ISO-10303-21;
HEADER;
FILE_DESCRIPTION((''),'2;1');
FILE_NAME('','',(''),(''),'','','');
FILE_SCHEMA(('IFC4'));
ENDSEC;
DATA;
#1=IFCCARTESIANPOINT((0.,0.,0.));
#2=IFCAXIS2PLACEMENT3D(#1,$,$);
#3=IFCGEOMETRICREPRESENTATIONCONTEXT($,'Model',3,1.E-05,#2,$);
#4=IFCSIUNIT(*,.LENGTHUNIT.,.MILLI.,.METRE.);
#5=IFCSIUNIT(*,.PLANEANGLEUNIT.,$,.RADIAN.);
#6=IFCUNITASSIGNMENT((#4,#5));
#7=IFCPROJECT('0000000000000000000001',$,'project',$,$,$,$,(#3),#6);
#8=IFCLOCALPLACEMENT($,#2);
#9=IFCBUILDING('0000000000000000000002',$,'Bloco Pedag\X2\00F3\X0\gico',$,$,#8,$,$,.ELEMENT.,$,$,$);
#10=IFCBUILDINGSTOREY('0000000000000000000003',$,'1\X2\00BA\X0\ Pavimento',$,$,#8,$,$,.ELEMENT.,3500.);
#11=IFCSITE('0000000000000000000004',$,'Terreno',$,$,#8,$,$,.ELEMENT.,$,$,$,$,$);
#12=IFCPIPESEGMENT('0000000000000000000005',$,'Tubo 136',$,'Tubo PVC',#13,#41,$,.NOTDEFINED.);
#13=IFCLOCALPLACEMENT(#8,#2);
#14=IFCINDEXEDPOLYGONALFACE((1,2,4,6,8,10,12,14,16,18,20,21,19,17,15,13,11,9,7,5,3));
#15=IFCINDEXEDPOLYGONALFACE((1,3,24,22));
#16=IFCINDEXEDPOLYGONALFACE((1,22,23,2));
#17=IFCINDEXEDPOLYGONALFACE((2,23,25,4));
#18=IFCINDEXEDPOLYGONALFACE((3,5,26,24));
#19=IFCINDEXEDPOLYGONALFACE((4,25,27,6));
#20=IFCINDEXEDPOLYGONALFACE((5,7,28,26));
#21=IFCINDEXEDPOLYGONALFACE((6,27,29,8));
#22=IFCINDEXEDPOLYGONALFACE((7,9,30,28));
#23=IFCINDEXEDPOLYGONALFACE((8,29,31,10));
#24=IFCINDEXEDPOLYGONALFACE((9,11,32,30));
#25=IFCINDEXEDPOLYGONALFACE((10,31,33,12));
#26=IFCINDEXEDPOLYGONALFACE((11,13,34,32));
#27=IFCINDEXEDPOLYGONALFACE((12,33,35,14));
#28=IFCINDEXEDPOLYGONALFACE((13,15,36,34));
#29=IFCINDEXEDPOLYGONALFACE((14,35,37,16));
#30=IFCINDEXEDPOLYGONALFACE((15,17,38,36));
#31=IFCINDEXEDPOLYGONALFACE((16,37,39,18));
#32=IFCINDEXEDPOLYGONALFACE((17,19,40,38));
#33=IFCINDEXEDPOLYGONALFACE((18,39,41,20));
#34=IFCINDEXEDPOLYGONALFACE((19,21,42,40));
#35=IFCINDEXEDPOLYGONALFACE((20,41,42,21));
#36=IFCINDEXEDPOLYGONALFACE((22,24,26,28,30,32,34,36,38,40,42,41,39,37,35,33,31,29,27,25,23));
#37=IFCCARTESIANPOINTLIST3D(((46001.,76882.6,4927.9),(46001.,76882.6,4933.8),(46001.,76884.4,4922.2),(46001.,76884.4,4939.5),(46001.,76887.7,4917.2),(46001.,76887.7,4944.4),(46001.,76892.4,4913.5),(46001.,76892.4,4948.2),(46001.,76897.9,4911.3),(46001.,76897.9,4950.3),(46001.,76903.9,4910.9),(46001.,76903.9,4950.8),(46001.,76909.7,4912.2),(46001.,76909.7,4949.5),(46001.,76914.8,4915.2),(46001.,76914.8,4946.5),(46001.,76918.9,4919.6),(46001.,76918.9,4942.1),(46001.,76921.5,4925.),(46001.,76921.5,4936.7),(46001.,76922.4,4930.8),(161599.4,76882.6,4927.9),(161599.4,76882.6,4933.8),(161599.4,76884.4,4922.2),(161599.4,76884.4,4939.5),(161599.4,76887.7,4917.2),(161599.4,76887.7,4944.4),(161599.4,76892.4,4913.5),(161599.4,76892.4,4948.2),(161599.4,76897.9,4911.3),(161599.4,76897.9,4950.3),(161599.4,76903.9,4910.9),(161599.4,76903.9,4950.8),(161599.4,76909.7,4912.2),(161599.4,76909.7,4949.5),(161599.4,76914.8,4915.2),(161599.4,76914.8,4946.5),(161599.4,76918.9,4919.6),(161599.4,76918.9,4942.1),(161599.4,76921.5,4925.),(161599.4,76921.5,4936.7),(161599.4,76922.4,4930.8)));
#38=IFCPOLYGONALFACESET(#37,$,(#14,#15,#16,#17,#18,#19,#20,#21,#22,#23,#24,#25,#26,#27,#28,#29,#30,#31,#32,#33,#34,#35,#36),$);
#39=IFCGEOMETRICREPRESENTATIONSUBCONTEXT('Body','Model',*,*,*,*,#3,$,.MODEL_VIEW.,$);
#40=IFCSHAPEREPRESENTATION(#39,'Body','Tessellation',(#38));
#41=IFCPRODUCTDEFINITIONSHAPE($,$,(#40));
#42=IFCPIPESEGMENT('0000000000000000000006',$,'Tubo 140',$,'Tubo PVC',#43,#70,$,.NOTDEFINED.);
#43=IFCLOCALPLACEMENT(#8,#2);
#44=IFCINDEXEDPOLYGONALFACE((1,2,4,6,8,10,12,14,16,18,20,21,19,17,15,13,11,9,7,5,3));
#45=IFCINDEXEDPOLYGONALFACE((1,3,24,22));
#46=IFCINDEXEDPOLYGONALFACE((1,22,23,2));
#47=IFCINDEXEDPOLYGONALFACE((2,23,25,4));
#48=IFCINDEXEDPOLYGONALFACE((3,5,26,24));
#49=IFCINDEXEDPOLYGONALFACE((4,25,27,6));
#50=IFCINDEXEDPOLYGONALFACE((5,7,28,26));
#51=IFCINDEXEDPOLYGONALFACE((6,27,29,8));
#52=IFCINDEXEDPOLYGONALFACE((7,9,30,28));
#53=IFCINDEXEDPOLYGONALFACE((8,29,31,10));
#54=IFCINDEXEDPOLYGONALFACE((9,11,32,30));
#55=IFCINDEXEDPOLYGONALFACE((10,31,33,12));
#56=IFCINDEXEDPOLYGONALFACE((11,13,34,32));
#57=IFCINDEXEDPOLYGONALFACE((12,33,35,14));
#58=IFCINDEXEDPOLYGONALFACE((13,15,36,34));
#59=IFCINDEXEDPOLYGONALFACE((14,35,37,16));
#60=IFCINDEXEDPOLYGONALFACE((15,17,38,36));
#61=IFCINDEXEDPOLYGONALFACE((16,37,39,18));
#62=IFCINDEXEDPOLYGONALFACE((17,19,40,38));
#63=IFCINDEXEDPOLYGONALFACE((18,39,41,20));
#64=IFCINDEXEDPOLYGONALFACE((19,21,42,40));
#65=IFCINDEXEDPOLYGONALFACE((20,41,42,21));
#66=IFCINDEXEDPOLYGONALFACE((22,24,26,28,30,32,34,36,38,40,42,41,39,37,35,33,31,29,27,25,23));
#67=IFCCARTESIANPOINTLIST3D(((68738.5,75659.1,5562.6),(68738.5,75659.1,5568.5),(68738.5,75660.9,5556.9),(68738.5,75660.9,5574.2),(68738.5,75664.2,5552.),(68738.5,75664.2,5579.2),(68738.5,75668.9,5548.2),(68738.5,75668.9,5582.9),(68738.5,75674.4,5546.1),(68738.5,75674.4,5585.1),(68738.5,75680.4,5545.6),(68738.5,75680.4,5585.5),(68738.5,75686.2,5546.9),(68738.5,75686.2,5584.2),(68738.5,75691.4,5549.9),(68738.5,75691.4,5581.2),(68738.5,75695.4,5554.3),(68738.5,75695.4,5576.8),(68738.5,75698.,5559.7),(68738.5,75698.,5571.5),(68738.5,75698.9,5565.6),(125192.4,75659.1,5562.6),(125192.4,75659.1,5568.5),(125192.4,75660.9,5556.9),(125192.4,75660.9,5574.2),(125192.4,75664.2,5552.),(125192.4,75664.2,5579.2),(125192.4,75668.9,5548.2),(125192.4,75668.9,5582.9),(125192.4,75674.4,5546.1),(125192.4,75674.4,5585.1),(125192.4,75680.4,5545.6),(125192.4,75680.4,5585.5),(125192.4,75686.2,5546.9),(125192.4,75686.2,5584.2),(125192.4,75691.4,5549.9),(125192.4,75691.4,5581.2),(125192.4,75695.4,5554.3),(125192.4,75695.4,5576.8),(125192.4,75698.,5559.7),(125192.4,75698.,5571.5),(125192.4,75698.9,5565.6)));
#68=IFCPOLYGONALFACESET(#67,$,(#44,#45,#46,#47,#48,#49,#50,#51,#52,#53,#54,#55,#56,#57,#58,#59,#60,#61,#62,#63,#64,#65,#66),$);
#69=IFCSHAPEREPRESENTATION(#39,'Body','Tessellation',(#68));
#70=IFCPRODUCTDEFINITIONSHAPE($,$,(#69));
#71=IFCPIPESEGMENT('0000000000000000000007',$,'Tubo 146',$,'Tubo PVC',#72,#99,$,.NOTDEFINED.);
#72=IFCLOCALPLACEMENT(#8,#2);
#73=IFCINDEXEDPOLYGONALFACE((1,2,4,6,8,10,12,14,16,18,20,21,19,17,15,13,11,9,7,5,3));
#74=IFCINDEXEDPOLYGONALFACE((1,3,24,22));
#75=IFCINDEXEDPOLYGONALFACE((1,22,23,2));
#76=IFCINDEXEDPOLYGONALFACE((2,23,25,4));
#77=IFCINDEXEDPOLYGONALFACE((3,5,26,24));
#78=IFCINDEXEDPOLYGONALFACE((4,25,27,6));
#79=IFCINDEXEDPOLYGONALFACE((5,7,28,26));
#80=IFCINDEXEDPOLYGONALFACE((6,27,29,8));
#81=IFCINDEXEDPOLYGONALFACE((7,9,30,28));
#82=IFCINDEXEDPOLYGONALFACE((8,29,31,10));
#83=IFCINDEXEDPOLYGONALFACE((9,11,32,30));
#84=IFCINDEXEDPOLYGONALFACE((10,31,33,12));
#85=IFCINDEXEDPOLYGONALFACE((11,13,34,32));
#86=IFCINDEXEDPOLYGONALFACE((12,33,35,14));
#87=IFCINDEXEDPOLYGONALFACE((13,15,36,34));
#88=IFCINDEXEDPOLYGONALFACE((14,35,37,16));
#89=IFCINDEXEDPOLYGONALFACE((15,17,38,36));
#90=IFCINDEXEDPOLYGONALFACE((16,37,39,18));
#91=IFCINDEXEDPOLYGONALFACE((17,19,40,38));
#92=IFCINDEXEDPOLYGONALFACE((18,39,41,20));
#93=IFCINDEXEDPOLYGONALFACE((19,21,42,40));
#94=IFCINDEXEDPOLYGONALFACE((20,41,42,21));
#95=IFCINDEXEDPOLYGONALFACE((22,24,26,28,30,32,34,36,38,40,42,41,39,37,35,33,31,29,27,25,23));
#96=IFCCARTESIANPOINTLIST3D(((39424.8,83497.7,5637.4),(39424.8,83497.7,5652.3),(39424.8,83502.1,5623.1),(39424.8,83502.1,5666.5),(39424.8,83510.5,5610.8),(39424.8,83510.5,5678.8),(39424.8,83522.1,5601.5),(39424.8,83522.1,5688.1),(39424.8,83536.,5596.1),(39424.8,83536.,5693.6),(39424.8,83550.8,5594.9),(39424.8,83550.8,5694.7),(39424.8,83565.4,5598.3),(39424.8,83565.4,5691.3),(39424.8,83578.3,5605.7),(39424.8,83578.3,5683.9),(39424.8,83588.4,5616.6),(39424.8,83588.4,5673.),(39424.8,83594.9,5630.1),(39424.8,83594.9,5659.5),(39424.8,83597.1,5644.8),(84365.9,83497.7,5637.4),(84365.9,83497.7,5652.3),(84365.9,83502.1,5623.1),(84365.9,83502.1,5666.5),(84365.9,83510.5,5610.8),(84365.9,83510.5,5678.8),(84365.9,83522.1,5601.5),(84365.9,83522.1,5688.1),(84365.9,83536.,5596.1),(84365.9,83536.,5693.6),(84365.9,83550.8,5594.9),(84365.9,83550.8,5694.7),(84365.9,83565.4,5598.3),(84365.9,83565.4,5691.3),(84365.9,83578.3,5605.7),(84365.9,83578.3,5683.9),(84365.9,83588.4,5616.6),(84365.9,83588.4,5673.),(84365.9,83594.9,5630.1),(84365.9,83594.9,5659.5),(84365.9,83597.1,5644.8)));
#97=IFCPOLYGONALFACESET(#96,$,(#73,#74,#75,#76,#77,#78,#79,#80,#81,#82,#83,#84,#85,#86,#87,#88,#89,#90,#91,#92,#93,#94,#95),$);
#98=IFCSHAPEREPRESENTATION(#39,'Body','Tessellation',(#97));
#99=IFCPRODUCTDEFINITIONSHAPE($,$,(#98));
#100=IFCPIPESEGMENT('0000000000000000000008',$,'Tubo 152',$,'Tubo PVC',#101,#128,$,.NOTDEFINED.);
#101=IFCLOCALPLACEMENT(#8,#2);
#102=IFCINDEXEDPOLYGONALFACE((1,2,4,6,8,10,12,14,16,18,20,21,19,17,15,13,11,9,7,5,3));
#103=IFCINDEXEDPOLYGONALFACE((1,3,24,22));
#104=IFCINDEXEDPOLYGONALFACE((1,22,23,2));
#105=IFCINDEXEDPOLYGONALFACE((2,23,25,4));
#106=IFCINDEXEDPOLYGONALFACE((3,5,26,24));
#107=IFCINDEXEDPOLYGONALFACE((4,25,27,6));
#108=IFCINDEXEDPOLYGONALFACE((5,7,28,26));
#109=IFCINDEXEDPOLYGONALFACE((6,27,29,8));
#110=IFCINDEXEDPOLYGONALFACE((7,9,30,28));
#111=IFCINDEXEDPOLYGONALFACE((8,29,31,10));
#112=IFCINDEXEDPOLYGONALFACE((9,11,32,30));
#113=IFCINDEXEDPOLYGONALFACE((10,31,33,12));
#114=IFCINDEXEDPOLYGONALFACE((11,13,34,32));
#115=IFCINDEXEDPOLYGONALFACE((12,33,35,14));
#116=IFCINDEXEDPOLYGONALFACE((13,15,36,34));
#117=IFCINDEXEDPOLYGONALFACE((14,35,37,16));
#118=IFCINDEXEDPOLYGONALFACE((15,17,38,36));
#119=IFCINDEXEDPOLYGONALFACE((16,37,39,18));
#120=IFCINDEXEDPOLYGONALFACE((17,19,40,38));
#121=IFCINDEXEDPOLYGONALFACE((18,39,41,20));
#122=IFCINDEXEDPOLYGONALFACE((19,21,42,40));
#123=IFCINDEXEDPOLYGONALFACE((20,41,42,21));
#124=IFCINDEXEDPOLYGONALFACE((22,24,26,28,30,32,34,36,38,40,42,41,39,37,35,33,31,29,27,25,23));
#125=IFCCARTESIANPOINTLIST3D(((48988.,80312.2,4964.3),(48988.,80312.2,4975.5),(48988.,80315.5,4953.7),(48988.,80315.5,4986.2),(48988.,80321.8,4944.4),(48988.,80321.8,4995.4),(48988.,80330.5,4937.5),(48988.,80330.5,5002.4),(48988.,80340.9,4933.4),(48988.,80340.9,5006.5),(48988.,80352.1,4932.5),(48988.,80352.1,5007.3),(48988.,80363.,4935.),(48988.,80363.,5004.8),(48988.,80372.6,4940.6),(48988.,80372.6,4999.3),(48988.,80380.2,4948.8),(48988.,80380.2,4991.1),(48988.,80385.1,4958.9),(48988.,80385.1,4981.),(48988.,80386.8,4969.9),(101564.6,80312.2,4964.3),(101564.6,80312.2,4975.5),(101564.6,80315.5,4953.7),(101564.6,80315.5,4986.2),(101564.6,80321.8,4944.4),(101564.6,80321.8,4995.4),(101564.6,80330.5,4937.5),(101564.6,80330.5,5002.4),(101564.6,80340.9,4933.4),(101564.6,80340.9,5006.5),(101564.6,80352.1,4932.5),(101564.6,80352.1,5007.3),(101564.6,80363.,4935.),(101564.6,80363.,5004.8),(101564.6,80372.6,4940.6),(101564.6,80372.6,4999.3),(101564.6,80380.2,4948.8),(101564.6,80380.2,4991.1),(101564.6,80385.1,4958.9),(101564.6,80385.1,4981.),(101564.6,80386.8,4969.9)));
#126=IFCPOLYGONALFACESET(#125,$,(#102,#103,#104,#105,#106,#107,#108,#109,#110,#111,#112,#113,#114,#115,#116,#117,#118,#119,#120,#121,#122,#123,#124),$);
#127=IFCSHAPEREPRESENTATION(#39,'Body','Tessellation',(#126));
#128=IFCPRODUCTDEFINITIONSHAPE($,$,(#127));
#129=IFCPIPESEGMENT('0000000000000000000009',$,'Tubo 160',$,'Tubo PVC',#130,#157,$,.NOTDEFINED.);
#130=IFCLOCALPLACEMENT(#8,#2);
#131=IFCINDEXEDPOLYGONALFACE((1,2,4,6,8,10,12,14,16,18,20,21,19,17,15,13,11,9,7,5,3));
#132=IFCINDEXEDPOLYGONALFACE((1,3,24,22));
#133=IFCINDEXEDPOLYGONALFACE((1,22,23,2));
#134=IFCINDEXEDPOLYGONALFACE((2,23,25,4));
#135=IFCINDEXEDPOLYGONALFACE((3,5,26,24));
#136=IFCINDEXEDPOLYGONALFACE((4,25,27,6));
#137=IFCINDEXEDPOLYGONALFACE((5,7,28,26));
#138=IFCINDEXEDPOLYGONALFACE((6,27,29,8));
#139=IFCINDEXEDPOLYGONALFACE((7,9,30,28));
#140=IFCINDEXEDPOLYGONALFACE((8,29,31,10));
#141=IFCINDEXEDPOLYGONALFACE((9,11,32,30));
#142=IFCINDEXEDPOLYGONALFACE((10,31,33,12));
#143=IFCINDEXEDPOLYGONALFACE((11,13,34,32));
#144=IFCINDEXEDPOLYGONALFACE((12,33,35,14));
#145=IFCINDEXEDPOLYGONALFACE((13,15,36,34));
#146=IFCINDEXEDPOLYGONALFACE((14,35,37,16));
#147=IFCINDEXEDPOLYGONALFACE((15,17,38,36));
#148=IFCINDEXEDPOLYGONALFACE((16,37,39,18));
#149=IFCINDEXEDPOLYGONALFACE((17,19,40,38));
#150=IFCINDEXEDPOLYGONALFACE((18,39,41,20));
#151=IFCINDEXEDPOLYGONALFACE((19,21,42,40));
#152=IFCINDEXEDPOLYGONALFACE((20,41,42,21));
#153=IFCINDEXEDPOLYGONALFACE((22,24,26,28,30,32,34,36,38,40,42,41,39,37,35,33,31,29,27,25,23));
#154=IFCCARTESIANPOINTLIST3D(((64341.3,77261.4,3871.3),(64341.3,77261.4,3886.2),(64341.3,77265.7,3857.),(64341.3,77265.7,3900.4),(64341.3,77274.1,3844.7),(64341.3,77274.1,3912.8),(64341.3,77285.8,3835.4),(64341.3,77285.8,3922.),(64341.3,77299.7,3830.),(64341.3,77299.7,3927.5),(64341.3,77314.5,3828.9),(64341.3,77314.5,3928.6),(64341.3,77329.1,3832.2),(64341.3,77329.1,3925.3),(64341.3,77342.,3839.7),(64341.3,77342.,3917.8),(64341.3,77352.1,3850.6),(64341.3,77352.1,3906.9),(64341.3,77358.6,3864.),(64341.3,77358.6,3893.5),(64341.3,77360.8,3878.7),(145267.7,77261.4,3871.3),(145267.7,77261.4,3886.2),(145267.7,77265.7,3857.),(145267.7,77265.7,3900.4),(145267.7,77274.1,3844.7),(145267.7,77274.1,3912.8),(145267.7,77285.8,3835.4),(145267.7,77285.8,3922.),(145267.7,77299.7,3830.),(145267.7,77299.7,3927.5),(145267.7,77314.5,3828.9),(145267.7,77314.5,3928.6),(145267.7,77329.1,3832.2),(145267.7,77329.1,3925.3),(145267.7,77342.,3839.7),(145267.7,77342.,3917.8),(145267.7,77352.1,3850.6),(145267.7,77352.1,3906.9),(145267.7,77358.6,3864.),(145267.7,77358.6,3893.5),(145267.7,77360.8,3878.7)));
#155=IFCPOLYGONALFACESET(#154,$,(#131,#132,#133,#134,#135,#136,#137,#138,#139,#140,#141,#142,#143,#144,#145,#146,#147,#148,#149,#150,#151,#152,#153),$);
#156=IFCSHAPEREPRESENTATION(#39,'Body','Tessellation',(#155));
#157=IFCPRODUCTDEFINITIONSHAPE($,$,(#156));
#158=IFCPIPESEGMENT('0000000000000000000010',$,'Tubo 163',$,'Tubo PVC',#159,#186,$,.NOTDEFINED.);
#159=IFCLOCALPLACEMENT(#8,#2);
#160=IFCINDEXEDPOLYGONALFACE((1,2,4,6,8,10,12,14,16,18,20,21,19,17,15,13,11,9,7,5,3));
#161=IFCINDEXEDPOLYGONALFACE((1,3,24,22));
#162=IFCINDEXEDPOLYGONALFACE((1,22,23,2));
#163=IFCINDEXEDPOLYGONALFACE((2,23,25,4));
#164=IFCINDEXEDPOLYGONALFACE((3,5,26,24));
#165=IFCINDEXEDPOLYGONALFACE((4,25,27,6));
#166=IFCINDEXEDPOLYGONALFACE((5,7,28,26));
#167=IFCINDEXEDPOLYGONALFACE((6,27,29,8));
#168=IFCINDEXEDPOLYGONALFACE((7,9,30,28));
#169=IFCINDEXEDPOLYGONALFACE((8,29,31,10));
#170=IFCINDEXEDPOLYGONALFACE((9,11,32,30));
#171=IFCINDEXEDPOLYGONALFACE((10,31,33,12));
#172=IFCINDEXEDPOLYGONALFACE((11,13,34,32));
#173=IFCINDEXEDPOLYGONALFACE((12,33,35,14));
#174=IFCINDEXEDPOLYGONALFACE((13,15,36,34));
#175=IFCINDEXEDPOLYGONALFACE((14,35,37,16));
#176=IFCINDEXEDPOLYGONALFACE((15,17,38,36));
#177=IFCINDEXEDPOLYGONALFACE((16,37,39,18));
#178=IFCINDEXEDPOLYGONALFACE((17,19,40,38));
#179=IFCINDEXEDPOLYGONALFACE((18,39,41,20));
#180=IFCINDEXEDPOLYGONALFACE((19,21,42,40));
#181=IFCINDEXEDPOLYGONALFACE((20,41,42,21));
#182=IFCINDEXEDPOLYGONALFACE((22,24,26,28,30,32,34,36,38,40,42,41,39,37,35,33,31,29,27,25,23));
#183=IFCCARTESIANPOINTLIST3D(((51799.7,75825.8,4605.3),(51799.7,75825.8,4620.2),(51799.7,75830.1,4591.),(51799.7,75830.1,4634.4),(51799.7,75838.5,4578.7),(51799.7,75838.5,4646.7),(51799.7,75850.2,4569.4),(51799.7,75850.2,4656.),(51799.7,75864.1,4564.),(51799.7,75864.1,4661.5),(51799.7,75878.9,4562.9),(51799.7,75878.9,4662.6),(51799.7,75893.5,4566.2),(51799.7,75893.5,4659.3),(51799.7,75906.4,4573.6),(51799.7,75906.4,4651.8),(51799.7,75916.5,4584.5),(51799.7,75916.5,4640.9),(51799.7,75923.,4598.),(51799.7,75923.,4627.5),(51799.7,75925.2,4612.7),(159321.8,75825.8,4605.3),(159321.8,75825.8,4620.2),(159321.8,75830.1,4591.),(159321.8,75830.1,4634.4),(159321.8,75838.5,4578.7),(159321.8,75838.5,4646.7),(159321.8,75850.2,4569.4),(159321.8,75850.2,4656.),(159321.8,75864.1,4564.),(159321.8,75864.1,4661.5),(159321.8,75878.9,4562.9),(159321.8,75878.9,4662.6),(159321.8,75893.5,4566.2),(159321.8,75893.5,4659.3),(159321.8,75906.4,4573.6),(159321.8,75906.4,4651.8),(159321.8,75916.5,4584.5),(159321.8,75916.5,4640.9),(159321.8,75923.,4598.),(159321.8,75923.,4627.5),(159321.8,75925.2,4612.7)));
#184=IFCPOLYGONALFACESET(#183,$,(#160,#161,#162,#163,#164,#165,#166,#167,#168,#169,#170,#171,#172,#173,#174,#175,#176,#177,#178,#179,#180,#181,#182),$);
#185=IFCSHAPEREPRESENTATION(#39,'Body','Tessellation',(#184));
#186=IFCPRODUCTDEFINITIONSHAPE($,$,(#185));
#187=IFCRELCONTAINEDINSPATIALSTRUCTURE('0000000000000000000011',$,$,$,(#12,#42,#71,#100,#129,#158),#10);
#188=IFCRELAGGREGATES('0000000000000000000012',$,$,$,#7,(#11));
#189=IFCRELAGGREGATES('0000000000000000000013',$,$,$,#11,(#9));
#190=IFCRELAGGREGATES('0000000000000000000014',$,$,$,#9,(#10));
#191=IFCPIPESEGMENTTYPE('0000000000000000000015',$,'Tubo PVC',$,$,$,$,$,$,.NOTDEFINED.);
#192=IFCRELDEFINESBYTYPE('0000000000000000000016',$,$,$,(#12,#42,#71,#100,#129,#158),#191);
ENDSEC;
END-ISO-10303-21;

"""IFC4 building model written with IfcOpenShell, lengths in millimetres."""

from ifc_helpers import new_model, si_unit, frame, origin, origin_2d, place, context, subcontext, project, spatial, circle, extrude, type_object, element, save


model = new_model("IFC4")

# Units and contexts
model_context = context("Model", 3, precision=1e-05, world=origin())
body_context = subcontext(model_context, "Body", "Model", "MODEL_VIEW")
ifc_project = project(units=[si_unit("LENGTHUNIT", "METRE", prefix="MILLI"), si_unit("PLANEANGLEUNIT", "RADIAN")], contexts=[model_context])

# Site, building, storey
placement = place(None, origin())
site = spatial("IfcSite", under=ifc_project, at=placement, Name="Terreno", CompositionType="ELEMENT")
building = spatial("IfcBuilding", under=site, at=placement, Name="Bloco Pedagógico", CompositionType="ELEMENT")
storey = spatial("IfcBuildingStorey", under=building, at=placement, Name="1º Pavimento", CompositionType="ELEMENT", Elevation=3500.0)

# Pipe segments
pipe_segment_type = type_object("IfcPipeSegmentType", Name="Tubo PVC", PredefinedType="NOTDEFINED")
pipe_segment_1_placement = place(None, frame((46001.0, 76902.4, 4930.8), z_axis=(1.0, 0.0, 0.0), x_axis=(0.0, 1.0, 0.0)))
element("IfcPipeSegment", 1, at=pipe_segment_1_placement, inside=storey, type_object=pipe_segment_type, Name="Tubo 136", ObjectType="Tubo PVC", PredefinedType="NOTDEFINED", context=body_context, shape_type="SweptSolid", body=[
    extrude(circle(Radius=20.0, at=origin_2d()), None, (0.0, 0.0, 1.0), 115598.4),
])
pipe_segment_2_placement = place(None, frame((68738.5, 75678.9, 5565.6), z_axis=(1.0, 0.0, 0.0), x_axis=(0.0, 1.0, 0.0)))
element("IfcPipeSegment", 2, at=pipe_segment_2_placement, inside=storey, type_object=pipe_segment_type, Name="Tubo 140", ObjectType="Tubo PVC", PredefinedType="NOTDEFINED", context=body_context, shape_type="SweptSolid", body=[
    extrude(circle(Radius=20.0, at=origin_2d()), None, (0.0, 0.0, 1.0), 56453.9),
])
pipe_segment_3_placement = place(None, frame((39424.8, 83547.1, 5644.8), z_axis=(1.0, 0.0, 0.0), x_axis=(0.0, 1.0, 0.0)))
element("IfcPipeSegment", 3, at=pipe_segment_3_placement, inside=storey, type_object=pipe_segment_type, Name="Tubo 146", ObjectType="Tubo PVC", PredefinedType="NOTDEFINED", context=body_context, shape_type="SweptSolid", body=[
    extrude(circle(Radius=50.0, at=origin_2d()), None, (0.0, 0.0, 1.0), 44941.1),
])
pipe_segment_4_placement = place(None, frame((48988.0, 80349.3, 4969.9), z_axis=(1.0, 0.0, 0.0), x_axis=(0.0, 1.0, 0.0)))
element("IfcPipeSegment", 4, at=pipe_segment_4_placement, inside=storey, type_object=pipe_segment_type, Name="Tubo 152", ObjectType="Tubo PVC", PredefinedType="NOTDEFINED", context=body_context, shape_type="SweptSolid", body=[
    extrude(circle(Radius=37.5, at=origin_2d()), None, (0.0, 0.0, 1.0), 52576.6),
])
pipe_segment_5_placement = place(None, frame((64341.3, 77310.8, 3878.7), z_axis=(1.0, 0.0, 0.0), x_axis=(0.0, 1.0, 0.0)))
element("IfcPipeSegment", 5, at=pipe_segment_5_placement, inside=storey, type_object=pipe_segment_type, Name="Tubo 160", ObjectType="Tubo PVC", PredefinedType="NOTDEFINED", context=body_context, shape_type="SweptSolid", body=[
    extrude(circle(Radius=50.0, at=origin_2d()), None, (0.0, 0.0, 1.0), 80926.4),
])
pipe_segment_6_placement = place(None, frame((51799.7, 75875.2, 4612.7), z_axis=(1.0, 0.0, 0.0), x_axis=(0.0, 1.0, 0.0)))
element("IfcPipeSegment", 6, at=pipe_segment_6_placement, inside=storey, type_object=pipe_segment_type, Name="Tubo 163", ObjectType="Tubo PVC", PredefinedType="NOTDEFINED", context=body_context, shape_type="SweptSolid", body=[
    extrude(circle(Radius=50.0, at=origin_2d()), None, (0.0, 0.0, 1.0), 107522.2),
])

save(model, "model.ifc")
